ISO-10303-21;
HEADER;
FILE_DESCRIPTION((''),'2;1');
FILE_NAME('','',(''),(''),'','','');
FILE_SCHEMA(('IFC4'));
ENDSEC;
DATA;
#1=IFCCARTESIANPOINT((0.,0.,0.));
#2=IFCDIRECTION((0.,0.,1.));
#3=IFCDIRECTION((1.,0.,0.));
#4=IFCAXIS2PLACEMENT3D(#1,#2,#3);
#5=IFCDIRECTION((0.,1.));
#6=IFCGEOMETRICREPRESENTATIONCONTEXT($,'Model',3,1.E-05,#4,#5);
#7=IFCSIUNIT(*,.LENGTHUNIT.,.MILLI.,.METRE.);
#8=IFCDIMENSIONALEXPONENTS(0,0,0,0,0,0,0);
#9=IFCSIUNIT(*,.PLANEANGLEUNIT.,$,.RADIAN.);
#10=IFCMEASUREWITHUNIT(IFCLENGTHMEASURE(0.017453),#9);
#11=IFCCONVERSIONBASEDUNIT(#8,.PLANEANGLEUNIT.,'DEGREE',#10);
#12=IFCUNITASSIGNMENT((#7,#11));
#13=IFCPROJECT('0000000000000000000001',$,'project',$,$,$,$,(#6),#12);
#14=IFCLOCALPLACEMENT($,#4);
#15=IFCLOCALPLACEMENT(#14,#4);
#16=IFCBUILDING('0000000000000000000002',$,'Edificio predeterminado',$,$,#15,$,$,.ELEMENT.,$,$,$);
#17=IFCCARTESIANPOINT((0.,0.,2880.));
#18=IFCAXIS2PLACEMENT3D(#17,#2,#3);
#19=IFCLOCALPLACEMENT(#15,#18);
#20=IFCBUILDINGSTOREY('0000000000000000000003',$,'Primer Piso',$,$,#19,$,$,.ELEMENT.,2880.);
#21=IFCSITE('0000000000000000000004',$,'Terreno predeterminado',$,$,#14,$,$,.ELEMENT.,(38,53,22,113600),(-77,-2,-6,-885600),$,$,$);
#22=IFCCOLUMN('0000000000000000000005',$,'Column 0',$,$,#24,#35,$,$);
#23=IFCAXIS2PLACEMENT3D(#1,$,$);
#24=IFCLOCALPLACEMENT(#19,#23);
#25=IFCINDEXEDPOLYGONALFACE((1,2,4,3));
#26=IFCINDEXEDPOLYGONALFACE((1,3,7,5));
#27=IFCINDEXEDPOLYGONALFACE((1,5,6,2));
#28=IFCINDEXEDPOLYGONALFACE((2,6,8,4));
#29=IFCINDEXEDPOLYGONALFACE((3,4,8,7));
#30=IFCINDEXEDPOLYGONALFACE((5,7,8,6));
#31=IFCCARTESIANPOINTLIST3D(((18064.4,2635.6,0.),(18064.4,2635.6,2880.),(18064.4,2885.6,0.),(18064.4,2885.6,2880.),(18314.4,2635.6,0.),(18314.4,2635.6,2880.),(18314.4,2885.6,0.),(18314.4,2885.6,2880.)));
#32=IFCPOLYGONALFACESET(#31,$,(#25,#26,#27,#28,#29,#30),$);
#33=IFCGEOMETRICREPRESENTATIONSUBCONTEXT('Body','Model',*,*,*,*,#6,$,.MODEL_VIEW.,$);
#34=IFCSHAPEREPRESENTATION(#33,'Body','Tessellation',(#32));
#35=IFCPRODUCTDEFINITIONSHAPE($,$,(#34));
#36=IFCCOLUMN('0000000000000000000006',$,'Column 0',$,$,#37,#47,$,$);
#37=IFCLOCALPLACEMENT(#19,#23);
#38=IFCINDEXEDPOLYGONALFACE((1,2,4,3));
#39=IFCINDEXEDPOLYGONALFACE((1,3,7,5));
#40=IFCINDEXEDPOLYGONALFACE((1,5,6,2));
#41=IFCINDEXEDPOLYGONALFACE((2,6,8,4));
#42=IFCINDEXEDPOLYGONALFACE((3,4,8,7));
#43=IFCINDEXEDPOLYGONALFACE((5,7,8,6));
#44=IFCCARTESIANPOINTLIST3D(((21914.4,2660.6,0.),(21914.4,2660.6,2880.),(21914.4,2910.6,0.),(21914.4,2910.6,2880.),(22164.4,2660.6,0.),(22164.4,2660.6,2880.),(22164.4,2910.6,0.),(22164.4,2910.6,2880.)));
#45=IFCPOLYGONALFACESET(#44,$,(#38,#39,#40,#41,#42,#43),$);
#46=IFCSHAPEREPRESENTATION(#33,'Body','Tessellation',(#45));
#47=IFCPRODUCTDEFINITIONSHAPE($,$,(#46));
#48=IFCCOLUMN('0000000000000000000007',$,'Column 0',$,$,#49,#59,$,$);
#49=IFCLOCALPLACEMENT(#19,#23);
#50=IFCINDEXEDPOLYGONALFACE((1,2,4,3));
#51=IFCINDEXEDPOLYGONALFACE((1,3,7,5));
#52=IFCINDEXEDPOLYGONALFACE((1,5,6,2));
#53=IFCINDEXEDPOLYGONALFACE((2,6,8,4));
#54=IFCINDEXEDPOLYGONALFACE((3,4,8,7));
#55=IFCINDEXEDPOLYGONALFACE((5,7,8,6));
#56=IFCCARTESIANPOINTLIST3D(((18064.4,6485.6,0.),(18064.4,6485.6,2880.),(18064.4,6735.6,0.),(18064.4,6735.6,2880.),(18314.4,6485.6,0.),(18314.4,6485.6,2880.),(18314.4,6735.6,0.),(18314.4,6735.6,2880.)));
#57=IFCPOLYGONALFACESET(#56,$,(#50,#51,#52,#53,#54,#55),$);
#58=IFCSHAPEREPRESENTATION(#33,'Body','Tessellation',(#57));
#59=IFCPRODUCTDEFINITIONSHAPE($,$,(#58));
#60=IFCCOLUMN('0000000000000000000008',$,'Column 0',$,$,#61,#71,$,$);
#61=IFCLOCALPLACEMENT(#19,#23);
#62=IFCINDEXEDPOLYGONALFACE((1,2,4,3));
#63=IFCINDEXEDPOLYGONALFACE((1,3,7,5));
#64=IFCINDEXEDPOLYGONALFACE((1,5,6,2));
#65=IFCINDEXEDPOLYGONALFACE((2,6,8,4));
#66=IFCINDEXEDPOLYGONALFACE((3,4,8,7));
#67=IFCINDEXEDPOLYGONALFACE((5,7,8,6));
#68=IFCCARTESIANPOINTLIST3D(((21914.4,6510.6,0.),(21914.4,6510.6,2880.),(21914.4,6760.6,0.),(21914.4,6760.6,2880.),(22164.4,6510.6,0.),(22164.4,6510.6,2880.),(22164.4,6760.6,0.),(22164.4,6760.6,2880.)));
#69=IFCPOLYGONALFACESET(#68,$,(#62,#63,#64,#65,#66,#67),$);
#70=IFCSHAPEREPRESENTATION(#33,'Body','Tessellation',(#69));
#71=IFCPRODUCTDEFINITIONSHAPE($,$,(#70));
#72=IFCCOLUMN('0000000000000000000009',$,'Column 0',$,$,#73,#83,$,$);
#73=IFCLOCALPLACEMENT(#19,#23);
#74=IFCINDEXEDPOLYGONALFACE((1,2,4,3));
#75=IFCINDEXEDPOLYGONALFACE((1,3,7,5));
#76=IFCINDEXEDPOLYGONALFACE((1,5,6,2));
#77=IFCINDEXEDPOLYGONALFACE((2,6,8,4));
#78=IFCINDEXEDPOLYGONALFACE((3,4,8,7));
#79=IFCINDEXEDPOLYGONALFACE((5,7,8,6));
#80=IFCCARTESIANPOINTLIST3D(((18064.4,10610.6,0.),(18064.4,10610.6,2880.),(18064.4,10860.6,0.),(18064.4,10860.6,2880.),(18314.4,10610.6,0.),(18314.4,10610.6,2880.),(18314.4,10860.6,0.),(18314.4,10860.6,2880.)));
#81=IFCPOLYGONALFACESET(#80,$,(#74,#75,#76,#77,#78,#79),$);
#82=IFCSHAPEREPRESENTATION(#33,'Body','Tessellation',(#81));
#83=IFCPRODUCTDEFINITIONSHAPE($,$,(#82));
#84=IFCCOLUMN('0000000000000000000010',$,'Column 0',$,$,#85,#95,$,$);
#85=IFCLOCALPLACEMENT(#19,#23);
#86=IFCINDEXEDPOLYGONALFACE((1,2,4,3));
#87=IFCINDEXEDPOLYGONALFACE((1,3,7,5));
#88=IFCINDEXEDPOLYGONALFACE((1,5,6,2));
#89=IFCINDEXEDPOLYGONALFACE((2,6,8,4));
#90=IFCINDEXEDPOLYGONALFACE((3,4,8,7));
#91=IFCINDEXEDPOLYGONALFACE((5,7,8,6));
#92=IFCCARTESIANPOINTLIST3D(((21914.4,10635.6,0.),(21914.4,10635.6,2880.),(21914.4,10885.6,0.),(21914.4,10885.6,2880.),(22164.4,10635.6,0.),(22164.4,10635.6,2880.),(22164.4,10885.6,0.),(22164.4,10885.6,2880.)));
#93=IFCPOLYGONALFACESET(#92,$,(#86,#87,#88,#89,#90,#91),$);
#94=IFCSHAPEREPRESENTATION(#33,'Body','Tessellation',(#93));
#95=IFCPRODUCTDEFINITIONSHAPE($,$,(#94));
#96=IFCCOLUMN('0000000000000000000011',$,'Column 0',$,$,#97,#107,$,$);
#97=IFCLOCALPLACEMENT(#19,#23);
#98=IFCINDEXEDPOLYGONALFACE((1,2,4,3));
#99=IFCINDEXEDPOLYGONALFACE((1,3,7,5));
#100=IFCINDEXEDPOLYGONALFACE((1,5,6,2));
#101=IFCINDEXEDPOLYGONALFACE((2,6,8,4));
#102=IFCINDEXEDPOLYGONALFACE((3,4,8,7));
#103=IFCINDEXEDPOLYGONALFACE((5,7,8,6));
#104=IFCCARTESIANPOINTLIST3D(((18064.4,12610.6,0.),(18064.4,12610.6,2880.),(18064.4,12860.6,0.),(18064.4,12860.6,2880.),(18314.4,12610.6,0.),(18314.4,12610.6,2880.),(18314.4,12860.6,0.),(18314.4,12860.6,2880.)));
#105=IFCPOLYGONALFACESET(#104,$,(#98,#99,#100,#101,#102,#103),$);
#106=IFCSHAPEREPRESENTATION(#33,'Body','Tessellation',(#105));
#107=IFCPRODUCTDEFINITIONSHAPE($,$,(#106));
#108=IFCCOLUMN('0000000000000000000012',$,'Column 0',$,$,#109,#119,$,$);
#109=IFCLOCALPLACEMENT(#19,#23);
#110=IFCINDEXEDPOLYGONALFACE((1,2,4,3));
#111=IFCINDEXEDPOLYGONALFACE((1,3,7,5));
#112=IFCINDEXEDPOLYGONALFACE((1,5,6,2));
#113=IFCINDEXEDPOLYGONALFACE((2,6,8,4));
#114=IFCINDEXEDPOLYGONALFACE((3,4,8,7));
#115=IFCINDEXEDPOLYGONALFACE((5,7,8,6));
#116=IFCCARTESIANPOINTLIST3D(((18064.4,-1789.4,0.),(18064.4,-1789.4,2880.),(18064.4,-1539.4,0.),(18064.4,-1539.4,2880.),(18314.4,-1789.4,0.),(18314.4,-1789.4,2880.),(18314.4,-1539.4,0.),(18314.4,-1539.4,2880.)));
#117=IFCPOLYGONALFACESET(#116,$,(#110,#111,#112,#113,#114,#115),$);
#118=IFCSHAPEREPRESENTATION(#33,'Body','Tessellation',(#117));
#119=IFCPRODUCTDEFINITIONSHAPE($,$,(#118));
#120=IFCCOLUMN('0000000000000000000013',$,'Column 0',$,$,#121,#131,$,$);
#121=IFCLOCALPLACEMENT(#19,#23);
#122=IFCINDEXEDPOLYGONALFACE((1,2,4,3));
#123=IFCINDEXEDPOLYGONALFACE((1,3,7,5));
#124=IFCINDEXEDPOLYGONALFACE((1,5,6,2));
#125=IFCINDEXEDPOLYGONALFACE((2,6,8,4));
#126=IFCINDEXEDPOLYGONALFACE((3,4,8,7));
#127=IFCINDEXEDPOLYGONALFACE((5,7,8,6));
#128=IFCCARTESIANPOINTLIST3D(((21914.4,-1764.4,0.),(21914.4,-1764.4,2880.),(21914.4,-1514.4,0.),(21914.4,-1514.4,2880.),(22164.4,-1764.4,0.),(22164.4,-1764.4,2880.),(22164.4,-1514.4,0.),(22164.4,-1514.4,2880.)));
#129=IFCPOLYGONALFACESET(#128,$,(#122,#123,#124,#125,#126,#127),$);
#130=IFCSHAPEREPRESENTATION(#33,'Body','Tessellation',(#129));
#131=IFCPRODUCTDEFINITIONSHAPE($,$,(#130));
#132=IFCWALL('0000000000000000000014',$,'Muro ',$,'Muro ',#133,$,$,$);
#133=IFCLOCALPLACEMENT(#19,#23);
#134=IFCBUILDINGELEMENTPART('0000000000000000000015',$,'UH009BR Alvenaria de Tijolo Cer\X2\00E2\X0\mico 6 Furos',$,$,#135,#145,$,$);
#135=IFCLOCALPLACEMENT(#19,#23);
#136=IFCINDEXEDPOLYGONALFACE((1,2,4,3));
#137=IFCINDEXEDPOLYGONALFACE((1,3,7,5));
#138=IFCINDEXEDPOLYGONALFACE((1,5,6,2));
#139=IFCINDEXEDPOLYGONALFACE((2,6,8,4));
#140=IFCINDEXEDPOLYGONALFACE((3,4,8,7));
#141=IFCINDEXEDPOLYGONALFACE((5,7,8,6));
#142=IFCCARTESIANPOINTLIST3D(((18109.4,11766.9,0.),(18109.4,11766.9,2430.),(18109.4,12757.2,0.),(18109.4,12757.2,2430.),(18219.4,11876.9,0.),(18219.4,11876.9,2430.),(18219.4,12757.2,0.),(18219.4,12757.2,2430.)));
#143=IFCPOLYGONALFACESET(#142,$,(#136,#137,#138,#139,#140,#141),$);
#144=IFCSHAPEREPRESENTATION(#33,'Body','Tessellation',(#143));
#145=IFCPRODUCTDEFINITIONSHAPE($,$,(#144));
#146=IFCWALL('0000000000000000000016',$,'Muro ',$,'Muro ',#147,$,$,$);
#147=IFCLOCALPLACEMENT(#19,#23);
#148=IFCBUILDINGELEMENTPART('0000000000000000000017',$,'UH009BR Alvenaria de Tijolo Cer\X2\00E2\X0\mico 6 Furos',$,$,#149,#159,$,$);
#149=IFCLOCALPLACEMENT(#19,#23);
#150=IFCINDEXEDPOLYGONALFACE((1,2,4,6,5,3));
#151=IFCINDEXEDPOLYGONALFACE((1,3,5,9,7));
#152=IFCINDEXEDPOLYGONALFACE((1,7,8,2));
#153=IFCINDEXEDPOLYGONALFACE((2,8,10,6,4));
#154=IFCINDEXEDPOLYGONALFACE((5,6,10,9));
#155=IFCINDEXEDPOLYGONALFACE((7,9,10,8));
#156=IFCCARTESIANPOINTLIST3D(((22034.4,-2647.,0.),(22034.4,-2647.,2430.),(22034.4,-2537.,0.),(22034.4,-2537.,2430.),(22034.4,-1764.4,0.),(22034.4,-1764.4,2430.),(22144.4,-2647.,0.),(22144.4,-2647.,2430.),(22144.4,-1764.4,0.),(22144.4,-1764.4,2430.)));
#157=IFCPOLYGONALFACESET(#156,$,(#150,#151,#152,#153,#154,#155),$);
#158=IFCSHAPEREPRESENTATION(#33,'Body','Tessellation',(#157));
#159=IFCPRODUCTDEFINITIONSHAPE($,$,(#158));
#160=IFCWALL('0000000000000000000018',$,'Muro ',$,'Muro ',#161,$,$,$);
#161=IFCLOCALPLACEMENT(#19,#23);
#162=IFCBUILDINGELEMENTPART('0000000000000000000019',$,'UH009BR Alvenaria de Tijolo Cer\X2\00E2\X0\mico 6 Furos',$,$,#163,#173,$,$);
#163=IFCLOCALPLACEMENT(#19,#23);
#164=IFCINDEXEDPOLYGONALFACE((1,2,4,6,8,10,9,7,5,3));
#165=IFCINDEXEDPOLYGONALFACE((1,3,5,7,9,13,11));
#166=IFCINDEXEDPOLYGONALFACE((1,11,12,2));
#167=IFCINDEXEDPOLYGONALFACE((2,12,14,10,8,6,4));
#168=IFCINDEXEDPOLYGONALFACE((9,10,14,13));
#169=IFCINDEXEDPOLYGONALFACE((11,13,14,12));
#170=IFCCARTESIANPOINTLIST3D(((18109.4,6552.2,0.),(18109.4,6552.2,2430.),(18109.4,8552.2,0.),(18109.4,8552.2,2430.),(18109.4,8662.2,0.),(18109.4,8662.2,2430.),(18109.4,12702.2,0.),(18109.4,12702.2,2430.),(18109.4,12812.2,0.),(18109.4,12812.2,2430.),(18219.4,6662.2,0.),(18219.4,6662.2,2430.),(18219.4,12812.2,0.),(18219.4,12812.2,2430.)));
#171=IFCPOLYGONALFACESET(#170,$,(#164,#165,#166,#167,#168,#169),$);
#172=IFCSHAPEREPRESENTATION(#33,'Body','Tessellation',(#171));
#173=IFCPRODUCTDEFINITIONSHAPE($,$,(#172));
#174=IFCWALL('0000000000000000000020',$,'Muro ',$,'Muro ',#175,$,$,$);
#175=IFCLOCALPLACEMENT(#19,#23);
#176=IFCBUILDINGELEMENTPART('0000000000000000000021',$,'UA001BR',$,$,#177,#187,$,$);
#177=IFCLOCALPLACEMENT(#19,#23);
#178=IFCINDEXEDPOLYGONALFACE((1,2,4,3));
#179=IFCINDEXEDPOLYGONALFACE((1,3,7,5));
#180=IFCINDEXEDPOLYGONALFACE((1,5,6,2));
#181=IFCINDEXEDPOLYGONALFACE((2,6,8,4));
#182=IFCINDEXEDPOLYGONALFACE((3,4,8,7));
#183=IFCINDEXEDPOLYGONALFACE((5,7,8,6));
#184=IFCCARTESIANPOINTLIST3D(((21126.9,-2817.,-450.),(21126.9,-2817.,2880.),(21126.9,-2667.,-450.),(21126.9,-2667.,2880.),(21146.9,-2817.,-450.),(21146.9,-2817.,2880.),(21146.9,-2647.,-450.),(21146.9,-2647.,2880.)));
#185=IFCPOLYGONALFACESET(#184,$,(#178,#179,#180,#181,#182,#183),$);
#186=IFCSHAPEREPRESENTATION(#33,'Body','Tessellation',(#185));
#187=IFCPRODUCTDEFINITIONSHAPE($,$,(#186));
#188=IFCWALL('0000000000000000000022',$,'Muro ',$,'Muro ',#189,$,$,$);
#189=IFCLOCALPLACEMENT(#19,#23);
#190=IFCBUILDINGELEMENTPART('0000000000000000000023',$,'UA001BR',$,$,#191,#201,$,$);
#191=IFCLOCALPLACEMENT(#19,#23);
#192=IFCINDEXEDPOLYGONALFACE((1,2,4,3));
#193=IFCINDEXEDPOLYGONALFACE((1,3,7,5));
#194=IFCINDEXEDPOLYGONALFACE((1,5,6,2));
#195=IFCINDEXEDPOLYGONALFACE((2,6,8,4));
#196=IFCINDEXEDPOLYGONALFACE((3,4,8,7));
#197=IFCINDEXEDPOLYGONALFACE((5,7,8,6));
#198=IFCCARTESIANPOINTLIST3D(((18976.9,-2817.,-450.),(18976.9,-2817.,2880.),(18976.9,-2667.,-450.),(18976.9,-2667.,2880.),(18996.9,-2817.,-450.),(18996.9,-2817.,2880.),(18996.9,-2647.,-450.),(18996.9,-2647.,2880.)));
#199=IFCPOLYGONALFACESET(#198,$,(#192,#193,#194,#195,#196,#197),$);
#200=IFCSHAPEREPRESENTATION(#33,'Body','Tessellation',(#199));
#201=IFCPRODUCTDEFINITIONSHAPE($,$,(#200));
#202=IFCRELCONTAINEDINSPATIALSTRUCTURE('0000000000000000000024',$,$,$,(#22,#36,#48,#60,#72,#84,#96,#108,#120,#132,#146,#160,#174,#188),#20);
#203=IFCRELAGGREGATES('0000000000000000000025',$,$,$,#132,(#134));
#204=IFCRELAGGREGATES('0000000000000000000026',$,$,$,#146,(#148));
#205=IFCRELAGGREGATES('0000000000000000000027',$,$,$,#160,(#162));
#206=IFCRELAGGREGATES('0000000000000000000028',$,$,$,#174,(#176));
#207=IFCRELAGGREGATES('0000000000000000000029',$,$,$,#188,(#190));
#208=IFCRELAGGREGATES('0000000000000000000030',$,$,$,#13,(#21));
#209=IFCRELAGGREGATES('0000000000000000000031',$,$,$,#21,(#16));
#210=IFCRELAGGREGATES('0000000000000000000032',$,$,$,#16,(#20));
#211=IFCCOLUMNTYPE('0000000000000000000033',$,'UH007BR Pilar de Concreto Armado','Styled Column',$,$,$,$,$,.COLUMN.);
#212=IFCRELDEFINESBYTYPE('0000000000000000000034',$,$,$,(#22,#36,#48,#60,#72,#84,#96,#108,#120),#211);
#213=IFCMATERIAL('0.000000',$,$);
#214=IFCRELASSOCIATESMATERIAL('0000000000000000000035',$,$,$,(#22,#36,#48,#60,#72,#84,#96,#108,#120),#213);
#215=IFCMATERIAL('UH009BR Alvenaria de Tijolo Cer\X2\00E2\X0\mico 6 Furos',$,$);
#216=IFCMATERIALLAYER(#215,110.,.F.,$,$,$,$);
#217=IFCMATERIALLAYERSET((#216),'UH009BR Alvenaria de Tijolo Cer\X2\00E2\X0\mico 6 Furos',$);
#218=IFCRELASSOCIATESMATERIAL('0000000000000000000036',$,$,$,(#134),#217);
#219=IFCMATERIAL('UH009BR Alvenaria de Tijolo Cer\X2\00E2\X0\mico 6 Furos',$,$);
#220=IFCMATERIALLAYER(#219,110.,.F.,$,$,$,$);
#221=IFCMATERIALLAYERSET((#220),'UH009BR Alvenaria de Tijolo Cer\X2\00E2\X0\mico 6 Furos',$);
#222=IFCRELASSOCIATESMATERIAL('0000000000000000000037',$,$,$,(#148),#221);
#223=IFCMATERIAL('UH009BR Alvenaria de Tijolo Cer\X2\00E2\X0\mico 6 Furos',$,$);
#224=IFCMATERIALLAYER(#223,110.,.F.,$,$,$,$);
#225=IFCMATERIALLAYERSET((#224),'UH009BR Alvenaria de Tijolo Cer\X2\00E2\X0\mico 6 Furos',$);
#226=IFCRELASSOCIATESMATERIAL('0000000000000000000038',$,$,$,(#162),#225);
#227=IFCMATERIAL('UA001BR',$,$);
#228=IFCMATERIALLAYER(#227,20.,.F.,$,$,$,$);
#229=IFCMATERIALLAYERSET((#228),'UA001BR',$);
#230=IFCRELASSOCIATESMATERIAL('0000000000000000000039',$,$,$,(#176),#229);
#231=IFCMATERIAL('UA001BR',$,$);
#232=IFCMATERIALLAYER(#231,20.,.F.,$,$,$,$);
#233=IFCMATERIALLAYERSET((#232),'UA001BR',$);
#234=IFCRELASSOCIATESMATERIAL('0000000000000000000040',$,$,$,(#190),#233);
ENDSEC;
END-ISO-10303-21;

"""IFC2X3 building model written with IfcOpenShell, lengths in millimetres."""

from ifc_helpers import new_model, entity, si_unit, converted_unit, direction, frame, origin_with_axes, place, context, subcontext, project, spatial, polyline, outline, extrude, clip, bounded_halfspace, material, layer, layer_set, layer_usage, type_object, element, aggregate, save


model = new_model("IFC2X3")

# Units and contexts
model_context = context("Model", 3, precision=1e-05, world=origin_with_axes(), true_north=direction((0.0, 1.0)))
body_context = subcontext(model_context, "Body", "Model", "MODEL_VIEW")
ifc_project = project(units=[si_unit("LENGTHUNIT", "METRE", prefix="MILLI"), converted_unit("PLANEANGLEUNIT", "DEGREE", entity("IfcLengthMeasure", 0.017453), si_unit("PLANEANGLEUNIT", "RADIAN"), dimensions=[0, 0, 0, 0, 0, 0, 0])], contexts=[model_context])

# Site, building, storey
site_placement = place(None, origin_with_axes())
site = spatial("IfcSite", under=ifc_project, at=site_placement, Name="Terreno predeterminado", CompositionType="ELEMENT", RefLatitude=(38, 53, 22, 113600), RefLongitude=(-77, -2, -6, -885600))
building_placement = place(site_placement, origin_with_axes())
building = spatial("IfcBuilding", under=site, at=building_placement, Name="Edificio predeterminado", CompositionType="ELEMENT")
storey_placement = place(building_placement, frame((0.0, 0.0, 2880.0), z_axis=(0.0, 0.0, 1.0), x_axis=(1.0, 0.0, 0.0)))
storey = spatial("IfcBuildingStorey", under=building, at=storey_placement, Name="Primer Piso", CompositionType="ELEMENT", Elevation=2880.0)

# Columns
ifc_material_1 = material(Name="0.000000")
column_type = type_object("IfcColumnType", Name="UH007BR Pilar de Concreto Armado", Description="Styled Column", PredefinedType="COLUMN")
for number, where, z_axis, x_axis, name in (
    (1, (18189.4, 2760.6, 0.0), (0.0, 0.0, 1.0), (1.0, 0.0, 0.0), "Column 0"),
    (2, (22039.4, 2785.6, 0.0), (0.0, 0.0, 1.0), (1.0, 0.0, 0.0), "Column 0"),
    (3, (18189.4, 6610.6, 0.0), (0.0, 0.0, 1.0), (1.0, 0.0, 0.0), "Column 0"),
    (4, (22039.4, 6635.6, 0.0), (0.0, 0.0, 1.0), (1.0, 0.0, 0.0), "Column 0"),
    (5, (18189.4, 10735.6, 0.0), (0.0, 0.0, 1.0), (1.0, 0.0, 0.0), "Column 0"),
    (6, (22039.4, 10760.6, 0.0), (0.0, 0.0, 1.0), (1.0, 0.0, 0.0), "Column 0"),
    (7, (18189.4, 12735.6, 0.0), (0.0, 0.0, 1.0), (1.0, 0.0, 0.0), "Column 0"),
    (8, (18189.4, -1664.4, 0.0), (0.0, 0.0, 1.0), (1.0, 0.0, 0.0), "Column 0"),
    (9, (22039.4, -1639.4, 0.0), (0.0, 0.0, 1.0), (1.0, 0.0, 0.0), "Column 0"),
):
    element("IfcColumn", number, at=place(storey_placement, frame(where, z_axis=z_axis, x_axis=x_axis)), inside=storey, type_object=column_type, material=ifc_material_1, Name=name, context=body_context, shape_type="SweptSolid", body=[
        extrude(outline(polyline([(-125.0, -125.0), (125.0, -125.0), (125.0, 125.0), (-125.0, 125.0), (-125.0, -125.0)])), origin_with_axes(), (0.0, 0.0, 1.0), 2880.0),
    ])

# Walls, building element parts
wall_1_placement = place(storey_placement, frame((18164.4, 11821.9, 0.0), z_axis=(0.0, 0.0, 1.0), x_axis=(0.0, 1.0, 0.0)))
wall_1 = element("IfcWall", 10, at=wall_1_placement, inside=storey, Name="Muro ", ObjectType="Muro ")
ifc_material_2 = material(Name="UH009BR Alvenaria de Tijolo Cerâmico 6 Furos")
ifc_layer_1 = layer(ifc_material_2, 110.0, ventilated=False)
ifc_layer_set_1 = layer_set([ifc_layer_1], Name="UH009BR Alvenaria de Tijolo Cerâmico 6 Furos")
ifc_layer_usage_1 = layer_usage(ifc_layer_set_1, "AXIS2", "NEGATIVE", -55.0)
building_element_part_1_placement = place(wall_1_placement, origin_with_axes())
building_element_part_1 = element("IfcBuildingElementPart", 11, at=building_element_part_1_placement, material=ifc_layer_usage_1, Name="UH009BR Alvenaria de Tijolo Cerâmico 6 Furos", context=body_context, shape_type="SweptSolid", body=[
    extrude(outline(polyline([(935.2, 55.0), (935.2, -55.0), (55.0, -55.0), (-55.0, 55.0), (935.2, 55.0)])), origin_with_axes(), (0.0, 0.0, 1.0), 2430.0),
])
aggregate(wall_1, [building_element_part_1])
wall_2_placement = place(storey_placement, frame((22089.4, -1764.4, 0.0), z_axis=(0.0, 0.0, 1.0), x_axis=(0.0, -1.0, 0.0)))
wall_2 = element("IfcWall", 12, at=wall_2_placement, inside=storey, Name="Muro ", ObjectType="Muro ")
ifc_material_3 = material(Name="UH009BR Alvenaria de Tijolo Cerâmico 6 Furos")
ifc_layer_2 = layer(ifc_material_3, 110.0, ventilated=False)
ifc_layer_set_2 = layer_set([ifc_layer_2], Name="UH009BR Alvenaria de Tijolo Cerâmico 6 Furos")
ifc_layer_usage_2 = layer_usage(ifc_layer_set_2, "AXIS2", "NEGATIVE", -55.0)
building_element_part_2_placement = place(wall_2_placement, origin_with_axes())
building_element_part_2 = element("IfcBuildingElementPart", 13, at=building_element_part_2_placement, material=ifc_layer_usage_2, Name="UH009BR Alvenaria de Tijolo Cerâmico 6 Furos", context=body_context, shape_type="SweptSolid", body=[
    extrude(outline(polyline([(882.6, 55.0), (882.6, -55.0), (772.6, -55.0), (0.0, -55.0), (0.0, 55.0), (882.6, 55.0)])), origin_with_axes(), (0.0, 0.0, 1.0), 2430.0),
])
aggregate(wall_2, [building_element_part_2])
wall_3_placement = place(storey_placement, frame((18164.4, 12757.2, 0.0), z_axis=(0.0, 0.0, 1.0), x_axis=(0.0, -1.0, 0.0)))
wall_3 = element("IfcWall", 14, at=wall_3_placement, inside=storey, Name="Muro ", ObjectType="Muro ")
ifc_material_4 = material(Name="UH009BR Alvenaria de Tijolo Cerâmico 6 Furos")
ifc_layer_3 = layer(ifc_material_4, 110.0, ventilated=False)
ifc_layer_set_3 = layer_set([ifc_layer_3], Name="UH009BR Alvenaria de Tijolo Cerâmico 6 Furos")
ifc_layer_usage_3 = layer_usage(ifc_layer_set_3, "AXIS2", "NEGATIVE", -55.0)
building_element_part_3_placement = place(wall_3_placement, origin_with_axes())
building_element_part_3 = element("IfcBuildingElementPart", 15, at=building_element_part_3_placement, material=ifc_layer_usage_3, Name="UH009BR Alvenaria de Tijolo Cerâmico 6 Furos", context=body_context, shape_type="SweptSolid", body=[
    extrude(outline(polyline([(6095.0, 55.0), (6205.0, -55.0), (4205.0, -55.0), (4095.0, -55.0), (55.0, -55.0), (-55.0, -55.0), (-55.0, 55.0), (6095.0, 55.0)])), origin_with_axes(), (0.0, 0.0, 1.0), 2430.0),
])
aggregate(wall_3, [building_element_part_3])
wall_4_placement = place(storey_placement, frame((21201.9, -2817.0, 0.0), z_axis=(0.0, 0.0, 1.0), x_axis=(0.0, 1.0, 0.0)))
wall_4 = element("IfcWall", 16, at=wall_4_placement, inside=storey, Name="Muro ", ObjectType="Muro ")
ifc_material_5 = material(Name="UA001BR")
ifc_layer_4 = layer(ifc_material_5, 20.0, ventilated=False)
ifc_layer_set_4 = layer_set([ifc_layer_4], Name="UA001BR")
ifc_layer_usage_4 = layer_usage(ifc_layer_set_4, "AXIS2", "NEGATIVE", -75.0)
building_element_part_4_placement = place(wall_4_placement, origin_with_axes())
building_element_part_4 = element("IfcBuildingElementPart", 17, at=building_element_part_4_placement, material=ifc_layer_usage_4, Name="UA001BR", context=body_context, shape_type="Clipping", body=[
    clip(clip(extrude(outline(polyline([(150.0, 75.0), (170.0, 55.0), (0.0, 55.0), (0.0, 75.0), (150.0, 75.0)])), frame((0.0, 0.0, -450.0), z_axis=(0.0, 0.0, 1.0), x_axis=(1.0, 0.0, 0.0)), (0.0, 0.0, 1.0), 3330.0), bounded_halfspace(frame((0.0, 0.0, -450.0), z_axis=(0.0, 0.0, 1.0), x_axis=(1.0, 0.0, 0.0)), True, origin_with_axes(), polyline([(-150.0, -150.0), (375.0, -150.0), (375.0, 150.0), (-150.0, 150.0), (-150.0, -150.0)]))), bounded_halfspace(frame((0.0, 0.0, 2880.0), z_axis=(0.0, 0.0, 1.0), x_axis=(1.0, 0.0, 0.0)), False, origin_with_axes(), polyline([(-150.0, -150.0), (375.0, -150.0), (375.0, 150.0), (-150.0, 150.0), (-150.0, -150.0)]))),
])
aggregate(wall_4, [building_element_part_4])
wall_5_placement = place(storey_placement, frame((19051.9, -2817.0, 0.0), z_axis=(0.0, 0.0, 1.0), x_axis=(0.0, 1.0, 0.0)))
wall_5 = element("IfcWall", 18, at=wall_5_placement, inside=storey, Name="Muro ", ObjectType="Muro ")
ifc_material_6 = material(Name="UA001BR")
ifc_layer_5 = layer(ifc_material_6, 20.0, ventilated=False)
ifc_layer_set_5 = layer_set([ifc_layer_5], Name="UA001BR")
ifc_layer_usage_5 = layer_usage(ifc_layer_set_5, "AXIS2", "NEGATIVE", -75.0)
building_element_part_5_placement = place(wall_5_placement, origin_with_axes())
building_element_part_5 = element("IfcBuildingElementPart", 19, at=building_element_part_5_placement, material=ifc_layer_usage_5, Name="UA001BR", context=body_context, shape_type="Clipping", body=[
    clip(clip(extrude(outline(polyline([(150.0, 75.0), (170.0, 55.0), (0.0, 55.0), (0.0, 75.0), (150.0, 75.0)])), frame((0.0, 0.0, -450.0), z_axis=(0.0, 0.0, 1.0), x_axis=(1.0, 0.0, 0.0)), (0.0, 0.0, 1.0), 3330.0), bounded_halfspace(frame((0.0, 0.0, -450.0), z_axis=(0.0, 0.0, 1.0), x_axis=(1.0, 0.0, 0.0)), True, origin_with_axes(), polyline([(-150.0, -150.0), (375.0, -150.0), (375.0, 150.0), (-150.0, 150.0), (-150.0, -150.0)]))), bounded_halfspace(frame((0.0, 0.0, 2880.0), z_axis=(0.0, 0.0, 1.0), x_axis=(1.0, 0.0, 0.0)), False, origin_with_axes(), polyline([(-150.0, -150.0), (375.0, -150.0), (375.0, 150.0), (-150.0, 150.0), (-150.0, -150.0)]))),
])
aggregate(wall_5, [building_element_part_5])

save(model, "model.ifc")
